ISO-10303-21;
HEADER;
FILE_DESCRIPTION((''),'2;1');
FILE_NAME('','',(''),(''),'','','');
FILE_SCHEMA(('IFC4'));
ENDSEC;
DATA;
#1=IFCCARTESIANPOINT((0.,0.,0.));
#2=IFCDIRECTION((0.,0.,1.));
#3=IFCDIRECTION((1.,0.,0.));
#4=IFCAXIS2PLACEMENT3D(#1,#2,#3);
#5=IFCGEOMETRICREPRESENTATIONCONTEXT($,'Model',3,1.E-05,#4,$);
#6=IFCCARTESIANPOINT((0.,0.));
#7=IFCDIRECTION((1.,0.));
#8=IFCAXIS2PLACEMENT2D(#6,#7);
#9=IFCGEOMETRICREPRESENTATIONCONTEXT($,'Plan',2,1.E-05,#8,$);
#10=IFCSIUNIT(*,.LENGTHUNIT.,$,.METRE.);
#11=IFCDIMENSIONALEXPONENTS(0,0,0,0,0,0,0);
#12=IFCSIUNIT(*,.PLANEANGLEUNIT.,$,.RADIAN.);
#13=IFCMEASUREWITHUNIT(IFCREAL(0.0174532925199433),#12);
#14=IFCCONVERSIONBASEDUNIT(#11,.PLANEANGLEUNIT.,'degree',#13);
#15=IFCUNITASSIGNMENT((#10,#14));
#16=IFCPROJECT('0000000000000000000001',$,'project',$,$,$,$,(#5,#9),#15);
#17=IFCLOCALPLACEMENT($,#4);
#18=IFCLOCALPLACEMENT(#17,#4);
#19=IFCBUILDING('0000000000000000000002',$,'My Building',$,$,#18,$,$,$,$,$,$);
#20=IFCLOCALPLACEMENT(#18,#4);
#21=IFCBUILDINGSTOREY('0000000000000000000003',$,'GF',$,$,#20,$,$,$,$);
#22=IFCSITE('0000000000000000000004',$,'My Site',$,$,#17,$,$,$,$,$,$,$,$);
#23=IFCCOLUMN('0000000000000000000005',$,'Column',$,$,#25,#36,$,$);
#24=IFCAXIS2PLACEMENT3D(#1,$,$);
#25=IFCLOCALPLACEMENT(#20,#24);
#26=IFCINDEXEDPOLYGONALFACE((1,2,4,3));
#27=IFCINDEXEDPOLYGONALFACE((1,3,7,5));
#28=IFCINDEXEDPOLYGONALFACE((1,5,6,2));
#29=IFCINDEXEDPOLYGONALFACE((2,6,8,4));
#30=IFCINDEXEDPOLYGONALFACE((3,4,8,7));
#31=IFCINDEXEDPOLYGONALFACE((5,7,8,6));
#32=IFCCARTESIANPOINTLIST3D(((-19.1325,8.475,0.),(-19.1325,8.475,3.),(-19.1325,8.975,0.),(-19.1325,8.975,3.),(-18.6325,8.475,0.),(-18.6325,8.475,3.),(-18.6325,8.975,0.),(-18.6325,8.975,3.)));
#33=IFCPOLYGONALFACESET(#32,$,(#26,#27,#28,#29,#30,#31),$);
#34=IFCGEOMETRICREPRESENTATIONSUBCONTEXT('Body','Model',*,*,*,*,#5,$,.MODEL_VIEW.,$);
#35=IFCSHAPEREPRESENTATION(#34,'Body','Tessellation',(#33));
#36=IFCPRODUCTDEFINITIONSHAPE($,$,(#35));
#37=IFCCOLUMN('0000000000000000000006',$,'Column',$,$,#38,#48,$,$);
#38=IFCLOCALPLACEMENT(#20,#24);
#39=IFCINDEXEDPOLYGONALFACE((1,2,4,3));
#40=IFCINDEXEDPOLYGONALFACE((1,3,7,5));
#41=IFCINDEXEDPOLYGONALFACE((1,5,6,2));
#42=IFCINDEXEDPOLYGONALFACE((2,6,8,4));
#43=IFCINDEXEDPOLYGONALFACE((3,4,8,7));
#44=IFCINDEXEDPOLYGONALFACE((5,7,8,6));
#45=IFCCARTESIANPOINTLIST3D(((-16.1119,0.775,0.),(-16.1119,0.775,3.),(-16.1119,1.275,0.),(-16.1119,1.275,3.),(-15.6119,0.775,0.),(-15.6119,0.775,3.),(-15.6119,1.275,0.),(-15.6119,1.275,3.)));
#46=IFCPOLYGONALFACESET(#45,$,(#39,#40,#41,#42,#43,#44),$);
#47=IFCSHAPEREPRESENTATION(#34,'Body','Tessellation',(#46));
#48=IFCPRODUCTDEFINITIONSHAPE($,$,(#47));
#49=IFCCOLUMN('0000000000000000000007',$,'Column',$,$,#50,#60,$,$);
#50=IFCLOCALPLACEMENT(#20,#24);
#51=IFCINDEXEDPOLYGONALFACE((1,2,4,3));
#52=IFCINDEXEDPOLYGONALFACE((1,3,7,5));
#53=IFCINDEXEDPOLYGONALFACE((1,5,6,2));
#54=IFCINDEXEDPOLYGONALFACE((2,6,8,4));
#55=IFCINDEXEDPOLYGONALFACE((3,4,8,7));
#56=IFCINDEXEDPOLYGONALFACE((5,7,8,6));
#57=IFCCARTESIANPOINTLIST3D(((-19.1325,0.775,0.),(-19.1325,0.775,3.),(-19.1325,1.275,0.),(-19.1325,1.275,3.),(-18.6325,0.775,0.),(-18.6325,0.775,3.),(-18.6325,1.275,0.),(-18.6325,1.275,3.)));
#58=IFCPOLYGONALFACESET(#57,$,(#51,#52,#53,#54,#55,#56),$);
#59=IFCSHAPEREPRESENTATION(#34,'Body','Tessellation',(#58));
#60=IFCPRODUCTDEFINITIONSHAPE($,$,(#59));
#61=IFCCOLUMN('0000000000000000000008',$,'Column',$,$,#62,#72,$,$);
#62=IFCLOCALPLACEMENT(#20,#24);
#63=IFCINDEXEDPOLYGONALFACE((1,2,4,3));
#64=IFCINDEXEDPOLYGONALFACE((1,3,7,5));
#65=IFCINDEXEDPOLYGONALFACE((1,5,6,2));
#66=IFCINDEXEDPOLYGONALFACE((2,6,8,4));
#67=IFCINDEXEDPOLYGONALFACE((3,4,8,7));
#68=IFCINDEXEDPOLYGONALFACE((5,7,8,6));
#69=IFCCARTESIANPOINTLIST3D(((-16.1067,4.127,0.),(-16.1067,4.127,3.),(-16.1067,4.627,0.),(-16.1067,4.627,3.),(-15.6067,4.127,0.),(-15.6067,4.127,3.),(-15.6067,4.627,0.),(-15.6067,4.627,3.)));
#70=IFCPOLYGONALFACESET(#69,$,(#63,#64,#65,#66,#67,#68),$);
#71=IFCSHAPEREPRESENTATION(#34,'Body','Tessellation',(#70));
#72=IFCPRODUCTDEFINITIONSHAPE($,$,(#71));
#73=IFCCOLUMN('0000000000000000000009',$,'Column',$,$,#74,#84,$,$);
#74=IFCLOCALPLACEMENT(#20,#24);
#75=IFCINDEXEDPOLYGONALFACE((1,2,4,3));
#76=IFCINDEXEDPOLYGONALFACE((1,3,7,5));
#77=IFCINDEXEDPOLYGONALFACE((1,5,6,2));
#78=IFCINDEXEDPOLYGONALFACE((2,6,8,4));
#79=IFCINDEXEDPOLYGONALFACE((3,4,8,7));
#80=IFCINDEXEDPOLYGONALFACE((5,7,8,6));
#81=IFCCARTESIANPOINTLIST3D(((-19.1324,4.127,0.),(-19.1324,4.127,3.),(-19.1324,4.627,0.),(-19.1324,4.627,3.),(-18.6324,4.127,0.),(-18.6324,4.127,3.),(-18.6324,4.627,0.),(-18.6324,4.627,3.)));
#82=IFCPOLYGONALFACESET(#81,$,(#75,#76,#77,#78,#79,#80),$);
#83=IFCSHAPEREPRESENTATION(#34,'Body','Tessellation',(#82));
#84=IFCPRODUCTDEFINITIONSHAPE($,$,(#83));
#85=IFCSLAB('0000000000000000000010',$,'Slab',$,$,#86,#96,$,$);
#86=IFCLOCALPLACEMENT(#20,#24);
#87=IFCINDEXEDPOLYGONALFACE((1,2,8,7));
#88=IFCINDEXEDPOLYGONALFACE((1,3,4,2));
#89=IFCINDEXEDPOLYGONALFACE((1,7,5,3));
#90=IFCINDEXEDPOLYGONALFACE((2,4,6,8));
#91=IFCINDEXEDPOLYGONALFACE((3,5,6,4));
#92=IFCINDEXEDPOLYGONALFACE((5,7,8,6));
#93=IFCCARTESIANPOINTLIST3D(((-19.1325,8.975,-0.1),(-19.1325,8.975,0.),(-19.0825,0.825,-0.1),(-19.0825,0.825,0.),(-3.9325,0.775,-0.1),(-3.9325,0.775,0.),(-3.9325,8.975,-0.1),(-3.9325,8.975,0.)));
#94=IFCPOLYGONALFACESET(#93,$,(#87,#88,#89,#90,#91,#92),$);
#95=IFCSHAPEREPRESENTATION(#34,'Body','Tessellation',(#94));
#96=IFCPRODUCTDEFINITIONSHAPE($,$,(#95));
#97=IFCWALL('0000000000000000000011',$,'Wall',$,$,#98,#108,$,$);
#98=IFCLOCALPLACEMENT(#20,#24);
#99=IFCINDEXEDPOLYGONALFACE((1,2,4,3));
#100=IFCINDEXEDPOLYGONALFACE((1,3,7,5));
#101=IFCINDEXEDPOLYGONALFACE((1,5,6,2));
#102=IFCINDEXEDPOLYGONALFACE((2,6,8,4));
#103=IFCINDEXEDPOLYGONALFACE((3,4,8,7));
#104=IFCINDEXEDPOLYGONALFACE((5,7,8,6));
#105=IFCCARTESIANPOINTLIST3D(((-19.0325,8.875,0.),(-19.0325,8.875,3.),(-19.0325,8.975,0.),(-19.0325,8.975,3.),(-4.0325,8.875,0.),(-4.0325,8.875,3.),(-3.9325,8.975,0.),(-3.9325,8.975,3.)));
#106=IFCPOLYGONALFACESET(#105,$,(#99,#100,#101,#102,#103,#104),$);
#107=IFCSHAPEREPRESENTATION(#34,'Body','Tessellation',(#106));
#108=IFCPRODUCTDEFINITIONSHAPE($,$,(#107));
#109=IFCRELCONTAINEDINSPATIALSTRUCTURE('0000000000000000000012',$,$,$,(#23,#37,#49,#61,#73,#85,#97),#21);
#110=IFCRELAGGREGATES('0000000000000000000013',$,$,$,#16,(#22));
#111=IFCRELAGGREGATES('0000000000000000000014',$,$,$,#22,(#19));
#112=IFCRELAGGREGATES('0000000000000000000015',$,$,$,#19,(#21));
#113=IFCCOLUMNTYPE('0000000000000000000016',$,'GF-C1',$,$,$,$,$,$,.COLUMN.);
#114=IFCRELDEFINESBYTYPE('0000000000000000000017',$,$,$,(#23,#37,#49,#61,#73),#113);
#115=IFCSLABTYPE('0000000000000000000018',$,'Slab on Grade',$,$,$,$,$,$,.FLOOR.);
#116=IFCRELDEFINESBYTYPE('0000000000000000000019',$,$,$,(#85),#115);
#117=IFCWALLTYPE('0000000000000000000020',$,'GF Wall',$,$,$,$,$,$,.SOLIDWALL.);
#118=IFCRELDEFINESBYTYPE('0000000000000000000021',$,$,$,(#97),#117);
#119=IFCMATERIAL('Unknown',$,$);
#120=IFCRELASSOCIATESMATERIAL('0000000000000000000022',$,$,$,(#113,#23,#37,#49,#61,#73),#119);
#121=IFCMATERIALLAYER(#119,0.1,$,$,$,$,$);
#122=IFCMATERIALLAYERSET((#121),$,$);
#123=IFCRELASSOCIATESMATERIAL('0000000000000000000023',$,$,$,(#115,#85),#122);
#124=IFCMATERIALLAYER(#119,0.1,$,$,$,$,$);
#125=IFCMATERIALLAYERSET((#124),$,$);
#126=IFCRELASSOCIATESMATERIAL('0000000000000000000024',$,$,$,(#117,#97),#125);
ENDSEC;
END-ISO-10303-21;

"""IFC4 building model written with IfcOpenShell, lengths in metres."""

from ifc_helpers import new_model, entity, si_unit, converted_unit, frame, origin_with_axes, origin_2d_with_axis, place, context, subcontext, project, spatial, line, indexed_curve, rectangle, outline, extrude, material, layer, layer_set, layer_usage, material_profile, profile_set, profile_usage, type_object, element, save


model = new_model("IFC4")

# Units and contexts
model_context = context("Model", 3, precision=1e-05, world=origin_with_axes())
plan_context = context("Plan", 2, precision=1e-05, world=origin_2d_with_axis())
body_context = subcontext(model_context, "Body", "Model", "MODEL_VIEW")
ifc_project = project(units=[si_unit("LENGTHUNIT", "METRE"), converted_unit("PLANEANGLEUNIT", "degree", entity("IfcReal", 0.0174532925199433), si_unit("PLANEANGLEUNIT", "RADIAN"), dimensions=[0, 0, 0, 0, 0, 0, 0])], contexts=[model_context, plan_context])

# Site, building, storey
site_placement = place(None, origin_with_axes())
site = spatial("IfcSite", under=ifc_project, at=site_placement, Name="My Site")
building_placement = place(site_placement, origin_with_axes())
building = spatial("IfcBuilding", under=site, at=building_placement, Name="My Building")
storey_placement = place(building_placement, origin_with_axes())
storey = spatial("IfcBuildingStorey", under=building, at=storey_placement, Name="GF")

# Columns
ifc_material = material(Name="Unknown")
ifc_material_profile = material_profile(ifc_material, rectangle(XDim=0.5, YDim=0.5))
ifc_profile_set = profile_set([ifc_material_profile])
ifc_profile_usage_1 = profile_usage(ifc_profile_set, cardinal=9)
column_type = type_object("IfcColumnType", Name="GF-C1", PredefinedType="COLUMN", material=ifc_profile_set)
column_1_placement = place(storey_placement, frame((-19.1325, 8.975, 0.0), z_axis=(0.0, 0.0, 1.0), x_axis=(1.0, 0.0, 0.0)))
element("IfcColumn", 1, at=column_1_placement, inside=storey, type_object=column_type, material=ifc_profile_usage_1, Name="Column", context=body_context, shape_type="SweptSolid", body=[
    extrude(rectangle(XDim=0.5, YDim=0.5), frame((0.25, -0.25, 0.0), z_axis=(0.0, 0.0, 1.0), x_axis=(1.0, 0.0, 0.0)), (0.0, 0.0, 1.0), 3.0),
])
ifc_profile_usage_2 = profile_usage(ifc_profile_set, cardinal=1)
column_2_placement = place(storey_placement, frame((-15.6119, 0.775, 0.0), z_axis=(0.0, 0.0, 1.0), x_axis=(1.0, 0.0, 0.0)))
element("IfcColumn", 2, at=column_2_placement, inside=storey, type_object=column_type, material=ifc_profile_usage_2, Name="Column", context=body_context, shape_type="SweptSolid", body=[
    extrude(rectangle(XDim=0.5, YDim=0.5), frame((-0.25, 0.25, 0.0), z_axis=(0.0, 0.0, 1.0), x_axis=(1.0, 0.0, 0.0)), (0.0, 0.0, 1.0), 3.0),
])
ifc_profile_usage_3 = profile_usage(ifc_profile_set, cardinal=3)
column_3_placement = place(storey_placement, frame((-19.1325, 0.775, 0.0), z_axis=(0.0, 0.0, 1.0), x_axis=(1.0, 0.0, 0.0)))
element("IfcColumn", 3, at=column_3_placement, inside=storey, type_object=column_type, material=ifc_profile_usage_3, Name="Column", context=body_context, shape_type="SweptSolid", body=[
    extrude(rectangle(XDim=0.5, YDim=0.5), frame((0.25, 0.25, 0.0), z_axis=(0.0, 0.0, 1.0), x_axis=(1.0, 0.0, 0.0)), (0.0, 0.0, 1.0), 3.0),
])
ifc_profile_usage_4 = profile_usage(ifc_profile_set, cardinal=4)
column_4_placement = place(storey_placement, frame((-15.6067, 4.377, 0.0), z_axis=(0.0, 0.0, 1.0), x_axis=(1.0, 0.0, 0.0)))
element("IfcColumn", 4, at=column_4_placement, inside=storey, type_object=column_type, material=ifc_profile_usage_4, Name="Column", context=body_context, shape_type="SweptSolid", body=[
    extrude(rectangle(XDim=0.5, YDim=0.5), frame((-0.25, 0.0, 0.0), z_axis=(0.0, 0.0, 1.0), x_axis=(1.0, 0.0, 0.0)), (0.0, 0.0, 1.0), 3.0),
])
ifc_profile_usage_5 = profile_usage(ifc_profile_set, cardinal=6)
column_5_placement = place(storey_placement, frame((-19.1324, 4.377, 0.0), z_axis=(0.0, 0.0, 1.0), x_axis=(1.0, 0.0, 0.0)))
element("IfcColumn", 5, at=column_5_placement, inside=storey, type_object=column_type, material=ifc_profile_usage_5, Name="Column", context=body_context, shape_type="SweptSolid", body=[
    extrude(rectangle(XDim=0.5, YDim=0.5), frame((0.25, 0.0, 0.0), z_axis=(0.0, 0.0, 1.0), x_axis=(1.0, 0.0, 0.0)), (0.0, 0.0, 1.0), 3.0),
])

# Slab
ifc_layer_1 = layer(ifc_material, 0.1)
ifc_layer_set_1 = layer_set([ifc_layer_1])
ifc_layer_usage_1 = layer_usage(ifc_layer_set_1, "AXIS3", "POSITIVE", -0.1)
slab_type = type_object("IfcSlabType", Name="Slab on Grade", PredefinedType="FLOOR", material=ifc_layer_set_1)
slab_placement = place(storey_placement, frame((-19.1325, 8.975, 0.0), z_axis=(0.0, 0.0, 1.0), x_axis=(1.0, 0.0, 0.0)))
element("IfcSlab", 6, at=slab_placement, inside=storey, type_object=slab_type, material=ifc_layer_usage_1, Name="Slab", context=body_context, shape_type="SweptSolid", body=[
    extrude(outline(indexed_curve([(0.0, 0.0), (15.2, 0.0), (15.2, -8.2), (0.05, -8.15), (0.0, 0.0)])), frame((0.0, 0.0, -0.1), z_axis=(0.0, 0.0, 1.0), x_axis=(1.0, 0.0, 0.0)), (0.0, 0.0, 1.0), 0.1),
])

# Wall
ifc_layer_2 = layer(ifc_material, 0.1)
ifc_layer_set_2 = layer_set([ifc_layer_2])
ifc_layer_usage_2 = layer_usage(ifc_layer_set_2, "AXIS2", "POSITIVE", 0.0)
wall_type = type_object("IfcWallType", Name="GF Wall", PredefinedType="SOLIDWALL", material=ifc_layer_set_2)
wall_1_placement = place(storey_placement, frame((-19.0325, 8.875, 0.0), z_axis=(0.0, 0.0, 1.0), x_axis=(1.0, 0.0, 0.0)))
element("IfcWall", 7, at=wall_1_placement, inside=storey, type_object=wall_type, material=ifc_layer_usage_2, Name="Wall", context=body_context, shape_type="SweptSolid", body=[
    extrude(outline(indexed_curve([(0.0, 0.0), (0.0, 0.1), (15.1, 0.1), (15.0, 0.0)], segments=[line(1, 2, 3, 4, 1)])), origin_with_axes(), (0.0, 0.0, 1.0), 3.0),
])

save(model, "model.ifc")
